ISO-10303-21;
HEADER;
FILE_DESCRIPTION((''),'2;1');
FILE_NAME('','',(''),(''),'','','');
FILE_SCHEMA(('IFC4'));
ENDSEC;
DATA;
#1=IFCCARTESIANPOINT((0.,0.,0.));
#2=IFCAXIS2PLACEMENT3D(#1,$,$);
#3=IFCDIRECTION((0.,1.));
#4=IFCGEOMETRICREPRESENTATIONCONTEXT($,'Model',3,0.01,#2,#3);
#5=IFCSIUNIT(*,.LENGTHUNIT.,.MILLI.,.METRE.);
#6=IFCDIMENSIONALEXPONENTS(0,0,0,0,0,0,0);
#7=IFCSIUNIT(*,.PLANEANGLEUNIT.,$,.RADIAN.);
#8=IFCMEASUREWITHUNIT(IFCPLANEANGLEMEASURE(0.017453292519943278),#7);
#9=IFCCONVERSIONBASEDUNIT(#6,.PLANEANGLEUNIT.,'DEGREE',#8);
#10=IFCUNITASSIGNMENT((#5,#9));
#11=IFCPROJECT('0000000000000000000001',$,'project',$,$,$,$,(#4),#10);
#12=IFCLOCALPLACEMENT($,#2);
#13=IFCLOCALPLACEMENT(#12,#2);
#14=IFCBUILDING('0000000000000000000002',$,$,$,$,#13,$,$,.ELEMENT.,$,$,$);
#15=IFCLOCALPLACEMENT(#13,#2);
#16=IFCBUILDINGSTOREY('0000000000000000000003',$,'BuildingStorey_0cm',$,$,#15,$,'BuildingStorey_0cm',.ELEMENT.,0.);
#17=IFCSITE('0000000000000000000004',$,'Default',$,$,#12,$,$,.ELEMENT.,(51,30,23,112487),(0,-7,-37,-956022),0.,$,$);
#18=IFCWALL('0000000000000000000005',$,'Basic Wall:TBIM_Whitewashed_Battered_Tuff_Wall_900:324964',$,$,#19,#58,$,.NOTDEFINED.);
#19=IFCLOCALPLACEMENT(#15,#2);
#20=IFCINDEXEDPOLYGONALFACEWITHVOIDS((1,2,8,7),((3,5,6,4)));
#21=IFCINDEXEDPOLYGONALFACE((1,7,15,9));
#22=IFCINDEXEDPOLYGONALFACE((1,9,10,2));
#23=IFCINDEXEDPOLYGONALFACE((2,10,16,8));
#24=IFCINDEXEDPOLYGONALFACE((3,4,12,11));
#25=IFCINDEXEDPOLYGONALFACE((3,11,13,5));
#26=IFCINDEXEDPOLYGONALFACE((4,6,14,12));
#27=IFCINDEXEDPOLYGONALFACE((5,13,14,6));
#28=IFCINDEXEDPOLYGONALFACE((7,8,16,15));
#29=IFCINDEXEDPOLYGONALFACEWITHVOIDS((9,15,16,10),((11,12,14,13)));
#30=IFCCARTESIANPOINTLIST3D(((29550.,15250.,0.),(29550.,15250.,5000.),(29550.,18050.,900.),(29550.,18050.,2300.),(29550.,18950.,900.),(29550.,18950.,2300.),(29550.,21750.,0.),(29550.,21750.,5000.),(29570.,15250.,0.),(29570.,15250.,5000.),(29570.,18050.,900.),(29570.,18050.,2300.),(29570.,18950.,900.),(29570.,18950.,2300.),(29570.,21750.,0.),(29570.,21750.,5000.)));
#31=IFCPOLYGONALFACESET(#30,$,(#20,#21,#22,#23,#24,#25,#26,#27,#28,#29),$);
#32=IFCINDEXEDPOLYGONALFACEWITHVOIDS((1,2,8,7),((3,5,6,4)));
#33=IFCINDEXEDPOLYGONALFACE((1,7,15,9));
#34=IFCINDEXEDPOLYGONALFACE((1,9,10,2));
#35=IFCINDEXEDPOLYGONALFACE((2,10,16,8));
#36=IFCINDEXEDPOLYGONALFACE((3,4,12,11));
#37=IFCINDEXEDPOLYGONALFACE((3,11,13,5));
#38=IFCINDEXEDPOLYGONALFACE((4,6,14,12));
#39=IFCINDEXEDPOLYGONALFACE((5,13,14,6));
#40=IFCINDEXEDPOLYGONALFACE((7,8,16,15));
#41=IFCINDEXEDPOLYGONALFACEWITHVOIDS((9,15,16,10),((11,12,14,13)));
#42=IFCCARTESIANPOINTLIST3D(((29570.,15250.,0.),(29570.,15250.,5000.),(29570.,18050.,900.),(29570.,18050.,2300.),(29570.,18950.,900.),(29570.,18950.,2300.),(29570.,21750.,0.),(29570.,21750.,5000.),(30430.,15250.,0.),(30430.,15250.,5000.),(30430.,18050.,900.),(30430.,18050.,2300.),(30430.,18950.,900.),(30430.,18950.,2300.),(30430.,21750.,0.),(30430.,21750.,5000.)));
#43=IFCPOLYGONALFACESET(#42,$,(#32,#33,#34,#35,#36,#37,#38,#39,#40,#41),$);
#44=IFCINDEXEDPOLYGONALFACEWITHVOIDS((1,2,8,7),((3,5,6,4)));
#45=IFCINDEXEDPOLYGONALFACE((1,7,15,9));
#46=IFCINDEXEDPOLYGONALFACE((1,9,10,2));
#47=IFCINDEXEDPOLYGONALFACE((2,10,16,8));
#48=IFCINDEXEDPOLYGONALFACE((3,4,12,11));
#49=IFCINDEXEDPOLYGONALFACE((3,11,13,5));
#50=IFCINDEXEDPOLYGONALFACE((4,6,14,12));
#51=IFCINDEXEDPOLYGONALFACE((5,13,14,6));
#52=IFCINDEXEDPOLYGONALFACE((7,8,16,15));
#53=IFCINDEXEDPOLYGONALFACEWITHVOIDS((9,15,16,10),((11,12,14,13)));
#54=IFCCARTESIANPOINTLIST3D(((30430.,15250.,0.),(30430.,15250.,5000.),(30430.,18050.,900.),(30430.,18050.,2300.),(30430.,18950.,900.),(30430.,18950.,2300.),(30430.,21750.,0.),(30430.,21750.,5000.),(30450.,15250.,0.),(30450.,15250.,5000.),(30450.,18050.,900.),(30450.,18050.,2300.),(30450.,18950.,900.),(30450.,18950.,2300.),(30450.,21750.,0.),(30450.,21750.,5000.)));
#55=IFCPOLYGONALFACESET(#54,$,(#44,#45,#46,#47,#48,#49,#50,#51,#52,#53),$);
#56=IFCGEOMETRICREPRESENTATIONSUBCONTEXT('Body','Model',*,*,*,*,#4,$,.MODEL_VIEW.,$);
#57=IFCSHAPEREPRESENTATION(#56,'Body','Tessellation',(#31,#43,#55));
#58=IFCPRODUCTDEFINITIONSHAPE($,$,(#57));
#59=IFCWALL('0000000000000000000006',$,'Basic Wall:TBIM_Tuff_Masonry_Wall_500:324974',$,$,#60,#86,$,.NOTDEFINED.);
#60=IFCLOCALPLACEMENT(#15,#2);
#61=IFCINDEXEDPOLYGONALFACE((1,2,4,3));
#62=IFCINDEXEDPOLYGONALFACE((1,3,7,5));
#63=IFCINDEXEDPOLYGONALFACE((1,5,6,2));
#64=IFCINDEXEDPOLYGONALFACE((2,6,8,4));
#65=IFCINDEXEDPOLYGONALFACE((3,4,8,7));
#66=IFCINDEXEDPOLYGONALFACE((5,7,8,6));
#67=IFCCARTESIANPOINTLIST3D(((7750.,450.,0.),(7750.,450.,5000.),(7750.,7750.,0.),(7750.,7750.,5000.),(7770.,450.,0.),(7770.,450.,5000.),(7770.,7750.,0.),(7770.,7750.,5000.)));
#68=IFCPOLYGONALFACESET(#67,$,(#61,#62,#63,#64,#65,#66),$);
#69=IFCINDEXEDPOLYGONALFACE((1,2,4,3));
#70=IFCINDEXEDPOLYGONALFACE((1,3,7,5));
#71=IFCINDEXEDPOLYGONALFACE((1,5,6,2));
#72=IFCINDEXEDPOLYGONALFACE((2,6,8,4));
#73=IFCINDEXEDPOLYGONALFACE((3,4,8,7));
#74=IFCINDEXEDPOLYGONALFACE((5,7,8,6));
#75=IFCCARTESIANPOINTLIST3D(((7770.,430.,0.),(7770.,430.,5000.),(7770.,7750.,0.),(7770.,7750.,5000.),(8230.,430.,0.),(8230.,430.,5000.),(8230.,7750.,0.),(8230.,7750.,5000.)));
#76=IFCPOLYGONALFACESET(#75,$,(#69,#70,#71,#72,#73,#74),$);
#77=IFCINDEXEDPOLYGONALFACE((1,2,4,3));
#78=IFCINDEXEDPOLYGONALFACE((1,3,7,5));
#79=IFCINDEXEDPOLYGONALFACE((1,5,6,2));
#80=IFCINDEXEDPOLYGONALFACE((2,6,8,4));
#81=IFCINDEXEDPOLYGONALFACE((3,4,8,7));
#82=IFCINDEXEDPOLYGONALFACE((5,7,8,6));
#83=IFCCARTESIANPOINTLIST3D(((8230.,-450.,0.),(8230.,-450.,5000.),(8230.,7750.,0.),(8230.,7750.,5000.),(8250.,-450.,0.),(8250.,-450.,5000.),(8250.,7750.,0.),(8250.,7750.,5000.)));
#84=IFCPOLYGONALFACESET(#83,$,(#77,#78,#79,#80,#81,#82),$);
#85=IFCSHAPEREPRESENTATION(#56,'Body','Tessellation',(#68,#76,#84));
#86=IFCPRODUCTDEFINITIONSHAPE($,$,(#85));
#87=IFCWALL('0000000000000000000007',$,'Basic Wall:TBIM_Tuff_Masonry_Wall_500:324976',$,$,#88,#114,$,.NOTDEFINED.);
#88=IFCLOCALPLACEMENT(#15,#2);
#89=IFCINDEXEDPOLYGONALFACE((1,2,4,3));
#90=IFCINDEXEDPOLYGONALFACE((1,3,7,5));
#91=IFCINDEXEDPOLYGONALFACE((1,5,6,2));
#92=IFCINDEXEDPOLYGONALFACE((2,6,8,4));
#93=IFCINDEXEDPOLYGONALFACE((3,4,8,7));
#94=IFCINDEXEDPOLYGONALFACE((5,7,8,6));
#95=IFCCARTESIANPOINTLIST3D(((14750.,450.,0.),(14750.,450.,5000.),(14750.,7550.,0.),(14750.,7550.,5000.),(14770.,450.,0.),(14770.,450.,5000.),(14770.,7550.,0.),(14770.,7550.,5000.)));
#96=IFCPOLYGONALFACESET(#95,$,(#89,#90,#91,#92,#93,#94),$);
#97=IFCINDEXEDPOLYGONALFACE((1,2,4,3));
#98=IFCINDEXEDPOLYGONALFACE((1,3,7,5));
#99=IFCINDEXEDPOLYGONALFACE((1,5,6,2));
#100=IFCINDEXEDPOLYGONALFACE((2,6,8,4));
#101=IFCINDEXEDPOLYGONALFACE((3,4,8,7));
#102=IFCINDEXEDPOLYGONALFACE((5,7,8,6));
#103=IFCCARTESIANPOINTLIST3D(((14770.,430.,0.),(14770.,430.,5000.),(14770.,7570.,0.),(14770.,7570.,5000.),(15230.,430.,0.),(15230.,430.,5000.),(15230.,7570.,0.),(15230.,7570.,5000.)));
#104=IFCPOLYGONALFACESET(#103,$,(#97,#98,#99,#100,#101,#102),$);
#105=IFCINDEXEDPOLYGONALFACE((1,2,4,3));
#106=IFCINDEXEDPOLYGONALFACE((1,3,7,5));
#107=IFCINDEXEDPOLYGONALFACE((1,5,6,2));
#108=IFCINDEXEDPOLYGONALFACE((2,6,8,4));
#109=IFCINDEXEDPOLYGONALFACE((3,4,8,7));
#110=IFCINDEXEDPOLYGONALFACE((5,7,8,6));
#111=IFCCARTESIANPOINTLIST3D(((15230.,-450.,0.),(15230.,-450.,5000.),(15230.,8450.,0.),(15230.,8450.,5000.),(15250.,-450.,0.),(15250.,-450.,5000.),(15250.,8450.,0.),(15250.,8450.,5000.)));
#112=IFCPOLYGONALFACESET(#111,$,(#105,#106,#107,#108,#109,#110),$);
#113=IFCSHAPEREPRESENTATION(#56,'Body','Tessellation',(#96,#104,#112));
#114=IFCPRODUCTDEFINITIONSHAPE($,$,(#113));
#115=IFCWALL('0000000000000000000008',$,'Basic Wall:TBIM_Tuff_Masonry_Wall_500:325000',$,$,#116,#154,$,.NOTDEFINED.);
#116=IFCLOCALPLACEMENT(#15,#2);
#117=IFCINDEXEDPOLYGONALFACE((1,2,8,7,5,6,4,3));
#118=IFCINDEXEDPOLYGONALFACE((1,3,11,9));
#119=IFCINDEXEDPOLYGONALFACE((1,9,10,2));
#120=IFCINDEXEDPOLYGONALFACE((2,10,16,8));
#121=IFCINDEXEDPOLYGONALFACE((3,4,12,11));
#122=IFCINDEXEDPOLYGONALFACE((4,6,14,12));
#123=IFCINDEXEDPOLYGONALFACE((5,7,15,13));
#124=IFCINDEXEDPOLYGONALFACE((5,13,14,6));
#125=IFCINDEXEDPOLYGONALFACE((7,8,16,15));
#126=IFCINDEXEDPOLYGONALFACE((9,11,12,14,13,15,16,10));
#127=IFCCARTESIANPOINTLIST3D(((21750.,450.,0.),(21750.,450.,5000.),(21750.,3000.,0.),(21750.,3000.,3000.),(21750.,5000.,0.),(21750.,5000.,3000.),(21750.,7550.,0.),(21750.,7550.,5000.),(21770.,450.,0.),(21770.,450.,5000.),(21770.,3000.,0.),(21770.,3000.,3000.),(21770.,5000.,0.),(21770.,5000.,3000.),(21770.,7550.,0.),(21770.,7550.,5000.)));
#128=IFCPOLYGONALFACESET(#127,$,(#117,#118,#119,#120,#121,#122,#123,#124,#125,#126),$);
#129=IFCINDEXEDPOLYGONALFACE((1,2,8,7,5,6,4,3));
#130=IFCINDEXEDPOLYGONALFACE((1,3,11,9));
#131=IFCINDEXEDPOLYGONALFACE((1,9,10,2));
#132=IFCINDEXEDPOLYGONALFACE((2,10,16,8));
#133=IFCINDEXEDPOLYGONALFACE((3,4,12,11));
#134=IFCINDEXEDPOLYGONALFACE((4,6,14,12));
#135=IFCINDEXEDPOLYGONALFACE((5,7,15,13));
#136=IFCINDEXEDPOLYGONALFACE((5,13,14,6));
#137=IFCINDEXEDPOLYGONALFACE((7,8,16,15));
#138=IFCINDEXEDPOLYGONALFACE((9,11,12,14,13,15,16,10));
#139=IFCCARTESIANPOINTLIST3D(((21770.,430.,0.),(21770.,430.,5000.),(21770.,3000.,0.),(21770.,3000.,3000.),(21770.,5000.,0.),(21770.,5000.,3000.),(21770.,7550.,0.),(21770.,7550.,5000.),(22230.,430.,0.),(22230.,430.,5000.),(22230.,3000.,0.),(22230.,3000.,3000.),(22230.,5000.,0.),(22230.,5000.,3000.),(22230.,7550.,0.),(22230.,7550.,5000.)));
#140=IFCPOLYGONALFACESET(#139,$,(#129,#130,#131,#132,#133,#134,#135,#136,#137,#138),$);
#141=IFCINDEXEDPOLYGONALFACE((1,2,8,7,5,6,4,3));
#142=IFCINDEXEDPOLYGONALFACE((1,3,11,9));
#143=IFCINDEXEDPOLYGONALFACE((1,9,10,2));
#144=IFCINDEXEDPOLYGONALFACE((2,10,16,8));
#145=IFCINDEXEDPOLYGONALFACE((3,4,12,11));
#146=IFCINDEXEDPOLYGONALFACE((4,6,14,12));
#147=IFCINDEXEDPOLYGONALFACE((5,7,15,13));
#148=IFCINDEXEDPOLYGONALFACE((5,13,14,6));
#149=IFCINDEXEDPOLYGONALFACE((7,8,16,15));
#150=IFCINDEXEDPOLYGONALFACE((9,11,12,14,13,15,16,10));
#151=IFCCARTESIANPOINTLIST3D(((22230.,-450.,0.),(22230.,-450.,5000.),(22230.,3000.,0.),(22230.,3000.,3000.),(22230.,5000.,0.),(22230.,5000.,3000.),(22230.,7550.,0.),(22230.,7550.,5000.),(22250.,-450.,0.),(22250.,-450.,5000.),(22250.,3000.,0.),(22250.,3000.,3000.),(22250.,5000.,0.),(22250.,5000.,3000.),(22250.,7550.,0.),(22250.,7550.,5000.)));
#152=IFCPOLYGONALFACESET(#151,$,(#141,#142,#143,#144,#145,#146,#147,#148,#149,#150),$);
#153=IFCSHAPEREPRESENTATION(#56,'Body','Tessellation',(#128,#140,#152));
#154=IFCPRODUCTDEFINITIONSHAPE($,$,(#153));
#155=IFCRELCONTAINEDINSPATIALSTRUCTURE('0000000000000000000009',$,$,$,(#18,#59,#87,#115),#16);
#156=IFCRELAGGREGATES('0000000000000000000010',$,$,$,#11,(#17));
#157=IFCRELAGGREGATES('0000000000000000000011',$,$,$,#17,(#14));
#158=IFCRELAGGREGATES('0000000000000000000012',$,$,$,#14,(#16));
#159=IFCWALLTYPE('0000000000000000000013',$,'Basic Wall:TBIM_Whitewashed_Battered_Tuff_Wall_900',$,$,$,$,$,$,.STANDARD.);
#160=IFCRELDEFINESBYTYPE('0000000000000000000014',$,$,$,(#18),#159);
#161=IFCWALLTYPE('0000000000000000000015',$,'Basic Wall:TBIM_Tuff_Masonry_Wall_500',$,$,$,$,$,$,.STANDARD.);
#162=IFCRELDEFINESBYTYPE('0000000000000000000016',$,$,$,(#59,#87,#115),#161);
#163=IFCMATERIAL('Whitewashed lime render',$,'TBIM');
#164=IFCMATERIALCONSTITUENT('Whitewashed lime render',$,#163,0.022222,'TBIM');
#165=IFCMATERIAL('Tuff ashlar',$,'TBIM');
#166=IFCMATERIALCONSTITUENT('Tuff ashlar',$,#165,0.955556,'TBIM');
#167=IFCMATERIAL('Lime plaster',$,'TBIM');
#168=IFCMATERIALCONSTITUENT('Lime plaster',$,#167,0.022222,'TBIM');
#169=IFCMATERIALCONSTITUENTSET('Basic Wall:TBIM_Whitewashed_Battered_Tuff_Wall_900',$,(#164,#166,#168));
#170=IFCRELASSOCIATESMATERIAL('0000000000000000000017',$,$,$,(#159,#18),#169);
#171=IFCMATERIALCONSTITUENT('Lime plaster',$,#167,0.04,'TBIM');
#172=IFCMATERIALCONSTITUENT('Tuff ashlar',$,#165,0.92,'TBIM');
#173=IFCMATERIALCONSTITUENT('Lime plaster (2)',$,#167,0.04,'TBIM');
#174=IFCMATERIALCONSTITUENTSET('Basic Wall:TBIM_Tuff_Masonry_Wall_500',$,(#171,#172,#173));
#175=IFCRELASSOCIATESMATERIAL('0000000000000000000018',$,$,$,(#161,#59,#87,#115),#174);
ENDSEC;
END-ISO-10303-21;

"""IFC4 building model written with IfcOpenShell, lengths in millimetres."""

from ifc_helpers import new_model, entity, si_unit, converted_unit, direction, frame, origin, place, context, subcontext, project, spatial, indexed_curve, outline, extrude, material, constituent, constituent_set, type_object, element, save


model = new_model("IFC4")

# Units and contexts
model_context = context("Model", 3, precision=0.01, world=origin(), true_north=direction((0.0, 1.0)))
body_context = subcontext(model_context, "Body", "Model", "MODEL_VIEW")
ifc_project = project(units=[si_unit("LENGTHUNIT", "METRE", prefix="MILLI"), converted_unit("PLANEANGLEUNIT", "DEGREE", entity("IfcPlaneAngleMeasure", 0.017453292519943278), si_unit("PLANEANGLEUNIT", "RADIAN"), dimensions=[0, 0, 0, 0, 0, 0, 0])], contexts=[model_context])

# Site, building, storey
site_placement = place(None, origin())
site = spatial("IfcSite", under=ifc_project, at=site_placement, Name="Default", CompositionType="ELEMENT", RefLatitude=(51, 30, 23, 112487), RefLongitude=(0, -7, -37, -956022), RefElevation=0.0)
building_placement = place(site_placement, origin())
building = spatial("IfcBuilding", under=site, at=building_placement, CompositionType="ELEMENT")
storey_placement = place(building_placement, origin())
storey = spatial("IfcBuildingStorey", under=building, at=storey_placement, Name="BuildingStorey_0cm", LongName="BuildingStorey_0cm", CompositionType="ELEMENT", Elevation=0.0)

# Shared definitions
ifc_material_1 = material(Name="Whitewashed lime render", Category="TBIM")
ifc_constituent_1 = constituent(ifc_material_1, Name="Whitewashed lime render", Category="TBIM", fraction=0.022222)
ifc_material_2 = material(Name="Tuff ashlar", Category="TBIM")
ifc_constituent_2 = constituent(ifc_material_2, Name="Tuff ashlar", Category="TBIM", fraction=0.955556)
ifc_material_3 = material(Name="Lime plaster", Category="TBIM")
ifc_constituent_3 = constituent(ifc_material_3, Name="Lime plaster", Category="TBIM", fraction=0.022222)
ifc_constituent_set_1 = constituent_set(constituents=[ifc_constituent_1, ifc_constituent_2, ifc_constituent_3], Name="Basic Wall:TBIM_Whitewashed_Battered_Tuff_Wall_900")
wall_type_1 = type_object("IfcWallType", Name="Basic Wall:TBIM_Whitewashed_Battered_Tuff_Wall_900", PredefinedType="STANDARD", material=ifc_constituent_set_1)

# Wall, opening
wall_1_placement = place(storey_placement, frame((30000.0, 15250.0, 0.0), z_axis=(0.0, 0.0, 1.0), x_axis=(0.0, 1.0, 0.0)))
wall_1 = element("IfcWall", 1, at=wall_1_placement, inside=storey, type_object=wall_type_1, material=ifc_constituent_set_1, Name="Basic Wall:TBIM_Whitewashed_Battered_Tuff_Wall_900:324964", PredefinedType="NOTDEFINED", context=body_context, shape_type="SweptSolid", body=[
    extrude(outline(indexed_curve([(-3250.0, -2500.0), (3250.0, -2500.0), (3250.0, 2500.0), (-3250.0, 2500.0), (-3250.0, -2500.0)], self_intersect=False), holes=[indexed_curve([(-450.0, -200.0), (450.0, -200.0), (450.0, -1600.0), (-450.0, -1600.0), (-450.0, -200.0)], self_intersect=False)]), frame((3250.0, 450.0, 2500.0), z_axis=(0.0, -1.0, 0.0), x_axis=(1.0, 0.0, 0.0)), (0.0, 0.0, 1.0), 20.0),
    extrude(outline(indexed_curve([(-2500.0, -3250.0), (2500.0, -3250.0), (2500.0, 3250.0), (-2500.0, 3250.0), (-2500.0, -3250.0)], self_intersect=False), holes=[indexed_curve([(-200.0, 450.0), (-200.0, -450.0), (-1600.0, -450.0), (-1600.0, 450.0), (-200.0, 450.0)], self_intersect=False)]), frame((3250.0, 430.0, 2500.0), z_axis=(0.0, -1.0, 0.0), x_axis=(0.0, 0.0, 1.0)), (0.0, 0.0, 1.0), 860.0),
    extrude(outline(indexed_curve([(-2500.0, -3250.0), (2500.0, -3250.0), (2500.0, 3250.0), (-2500.0, 3250.0), (-2500.0, -3250.0)], self_intersect=False), holes=[indexed_curve([(-200.0, 450.0), (-200.0, -450.0), (-1600.0, -450.0), (-1600.0, 450.0), (-200.0, 450.0)], self_intersect=False)]), frame((3250.0, -430.0, 2500.0), z_axis=(0.0, -1.0, 0.0), x_axis=(0.0, 0.0, 1.0)), (0.0, 0.0, 1.0), 20.0),
])
opening_1_placement = place(wall_1_placement, frame((2800.0, -450.0, 900.0)))
element("IfcOpeningElement", 2, at=opening_1_placement, cuts=wall_1, PredefinedType="OPENING", context=body_context, shape_type="SweptSolid", body=[
    extrude(outline(indexed_curve([(1400.0, 0.0), (1400.0, 900.0), (0.0, 900.0), (0.0, 0.0), (1400.0, 0.0)], self_intersect=False)), frame((0.0, 0.0, 0.0), z_axis=(0.0, 1.0, 0.0), x_axis=(0.0, 0.0, 1.0)), (0.0, 0.0, 1.0), 900.0),
])

# Walls
ifc_constituent_4 = constituent(ifc_material_3, Name="Lime plaster", Category="TBIM", fraction=0.04)
ifc_constituent_5 = constituent(ifc_material_2, Name="Tuff ashlar", Category="TBIM", fraction=0.92)
ifc_constituent_6 = constituent(ifc_material_3, Name="Lime plaster (2)", Category="TBIM", fraction=0.04)
ifc_constituent_set_2 = constituent_set(constituents=[ifc_constituent_4, ifc_constituent_5, ifc_constituent_6], Name="Basic Wall:TBIM_Tuff_Masonry_Wall_500")
wall_type_2 = type_object("IfcWallType", Name="Basic Wall:TBIM_Tuff_Masonry_Wall_500", PredefinedType="STANDARD", material=ifc_constituent_set_2)
wall_2_placement = place(storey_placement, frame((8000.0, 450.0, 0.0), z_axis=(0.0, 0.0, 1.0), x_axis=(0.0, 1.0, 0.0)))
element("IfcWall", 3, at=wall_2_placement, inside=storey, type_object=wall_type_2, material=ifc_constituent_set_2, Name="Basic Wall:TBIM_Tuff_Masonry_Wall_500:324974", PredefinedType="NOTDEFINED", context=body_context, shape_type="SweptSolid", body=[
    extrude(outline(indexed_curve([(-10.0, -3650.0), (10.0, -3650.0), (10.0, 3650.0), (-10.0, 3650.0), (-10.0, -3650.0)], self_intersect=False)), frame((3650.0, 240.0, 0.0), z_axis=(0.0, 0.0, 1.0), x_axis=(0.0, -1.0, 0.0)), (0.0, 0.0, 1.0), 5000.0),
    extrude(outline(indexed_curve([(-3660.0, -230.0), (3660.0, -230.0), (3660.0, 230.0), (-3660.0, 230.0), (-3660.0, -230.0)], self_intersect=False)), frame((3640.0, 0.0, 0.0)), (0.0, 0.0, 1.0), 5000.0),
    extrude(outline(indexed_curve([(-10.0, -4100.0), (10.0, -4100.0), (10.0, 4100.0), (-10.0, 4100.0), (-10.0, -4100.0)], self_intersect=False)), frame((3200.0, -240.0, 0.0), z_axis=(0.0, 0.0, 1.0), x_axis=(0.0, 1.0, 0.0)), (0.0, 0.0, 1.0), 5000.0),
])
wall_3_placement = place(storey_placement, frame((15000.0, 450.0, 0.0), z_axis=(0.0, 0.0, 1.0), x_axis=(0.0, 1.0, 0.0)))
element("IfcWall", 4, at=wall_3_placement, inside=storey, type_object=wall_type_2, material=ifc_constituent_set_2, Name="Basic Wall:TBIM_Tuff_Masonry_Wall_500:324976", PredefinedType="NOTDEFINED", context=body_context, shape_type="SweptSolid", body=[
    extrude(outline(indexed_curve([(-10.0, -3550.0), (10.0, -3550.0), (10.0, 3550.0), (-10.0, 3550.0), (-10.0, -3550.0)], self_intersect=False)), frame((3550.0, 240.0, 0.0), z_axis=(0.0, 0.0, 1.0), x_axis=(0.0, -1.0, 0.0)), (0.0, 0.0, 1.0), 5000.0),
    extrude(outline(indexed_curve([(-3570.0, -230.0), (3570.0, -230.0), (3570.0, 230.0), (-3570.0, 230.0), (-3570.0, -230.0)], self_intersect=False)), frame((3550.0, 0.0, 0.0)), (0.0, 0.0, 1.0), 5000.0),
    extrude(outline(indexed_curve([(-10.0, -4450.0), (10.0, -4450.0), (10.0, 4450.0), (-10.0, 4450.0), (-10.0, -4450.0)], self_intersect=False)), frame((3550.0, -240.0, 0.0), z_axis=(0.0, 0.0, 1.0), x_axis=(0.0, 1.0, 0.0)), (0.0, 0.0, 1.0), 5000.0),
])

# Wall, opening
wall_4_placement = place(storey_placement, frame((22000.0, 450.0, 0.0), z_axis=(0.0, 0.0, 1.0), x_axis=(0.0, 1.0, 0.0)))
wall_4 = element("IfcWall", 5, at=wall_4_placement, inside=storey, type_object=wall_type_2, material=ifc_constituent_set_2, Name="Basic Wall:TBIM_Tuff_Masonry_Wall_500:325000", PredefinedType="NOTDEFINED", context=body_context, shape_type="SweptSolid", body=[
    extrude(outline(indexed_curve([(-2000.0, -3550.0), (3000.0, -3550.0), (3000.0, 3550.0), (-2000.0, 3550.0), (-2000.0, 1000.0), (1000.0, 1000.0), (1000.0, -1000.0), (-2000.0, -1000.0), (-2000.0, -3550.0)], self_intersect=False)), frame((3550.0, 250.0, 2000.0), z_axis=(0.0, -1.0, 0.0), x_axis=(0.0, 0.0, 1.0)), (0.0, 0.0, 1.0), 20.0),
    extrude(outline(indexed_curve([(-2000.0, -995.0), (-2000.0, -3565.0), (3000.0, -3565.0), (3000.0, 3555.0), (-2000.0, 3555.0), (-2000.0, 1005.0), (1000.0, 1005.0), (1000.0, -995.0), (-2000.0, -995.0)], self_intersect=False)), frame((3545.0, 230.0, 2000.0), z_axis=(0.0, 1.0, 0.0), x_axis=(0.0, 0.0, 1.0)), (0.0, 0.0, -1.0), 460.0),
    extrude(outline(indexed_curve([(-2000.0, -775.0), (-2000.0, -4225.0), (3000.0, -4225.0), (3000.0, 3775.0), (-2000.0, 3775.0), (-2000.0, 1225.0), (1000.0, 1225.0), (1000.0, -775.0), (-2000.0, -775.0)], self_intersect=False)), frame((3325.0, -230.0, 2000.0), z_axis=(0.0, 1.0, 0.0), x_axis=(0.0, 0.0, 1.0)), (0.0, 0.0, -1.0), 20.0),
])
opening_2_placement = place(wall_4_placement, frame((4550.0, 250.0, 0.0)))
element("IfcOpeningElement", 6, at=opening_2_placement, cuts=wall_4, PredefinedType="OPENING", context=body_context, shape_type="SweptSolid", body=[
    extrude(outline(indexed_curve([(3000.0, 2000.0), (0.0, 2000.0), (0.0, 0.0), (3000.0, 0.0), (3000.0, 2000.0)], self_intersect=False)), frame((0.0, 0.0, 0.0), z_axis=(0.0, -1.0, 0.0), x_axis=(0.0, 0.0, 1.0)), (0.0, 0.0, 1.0), 500.0),
])

save(model, "model.ifc")
